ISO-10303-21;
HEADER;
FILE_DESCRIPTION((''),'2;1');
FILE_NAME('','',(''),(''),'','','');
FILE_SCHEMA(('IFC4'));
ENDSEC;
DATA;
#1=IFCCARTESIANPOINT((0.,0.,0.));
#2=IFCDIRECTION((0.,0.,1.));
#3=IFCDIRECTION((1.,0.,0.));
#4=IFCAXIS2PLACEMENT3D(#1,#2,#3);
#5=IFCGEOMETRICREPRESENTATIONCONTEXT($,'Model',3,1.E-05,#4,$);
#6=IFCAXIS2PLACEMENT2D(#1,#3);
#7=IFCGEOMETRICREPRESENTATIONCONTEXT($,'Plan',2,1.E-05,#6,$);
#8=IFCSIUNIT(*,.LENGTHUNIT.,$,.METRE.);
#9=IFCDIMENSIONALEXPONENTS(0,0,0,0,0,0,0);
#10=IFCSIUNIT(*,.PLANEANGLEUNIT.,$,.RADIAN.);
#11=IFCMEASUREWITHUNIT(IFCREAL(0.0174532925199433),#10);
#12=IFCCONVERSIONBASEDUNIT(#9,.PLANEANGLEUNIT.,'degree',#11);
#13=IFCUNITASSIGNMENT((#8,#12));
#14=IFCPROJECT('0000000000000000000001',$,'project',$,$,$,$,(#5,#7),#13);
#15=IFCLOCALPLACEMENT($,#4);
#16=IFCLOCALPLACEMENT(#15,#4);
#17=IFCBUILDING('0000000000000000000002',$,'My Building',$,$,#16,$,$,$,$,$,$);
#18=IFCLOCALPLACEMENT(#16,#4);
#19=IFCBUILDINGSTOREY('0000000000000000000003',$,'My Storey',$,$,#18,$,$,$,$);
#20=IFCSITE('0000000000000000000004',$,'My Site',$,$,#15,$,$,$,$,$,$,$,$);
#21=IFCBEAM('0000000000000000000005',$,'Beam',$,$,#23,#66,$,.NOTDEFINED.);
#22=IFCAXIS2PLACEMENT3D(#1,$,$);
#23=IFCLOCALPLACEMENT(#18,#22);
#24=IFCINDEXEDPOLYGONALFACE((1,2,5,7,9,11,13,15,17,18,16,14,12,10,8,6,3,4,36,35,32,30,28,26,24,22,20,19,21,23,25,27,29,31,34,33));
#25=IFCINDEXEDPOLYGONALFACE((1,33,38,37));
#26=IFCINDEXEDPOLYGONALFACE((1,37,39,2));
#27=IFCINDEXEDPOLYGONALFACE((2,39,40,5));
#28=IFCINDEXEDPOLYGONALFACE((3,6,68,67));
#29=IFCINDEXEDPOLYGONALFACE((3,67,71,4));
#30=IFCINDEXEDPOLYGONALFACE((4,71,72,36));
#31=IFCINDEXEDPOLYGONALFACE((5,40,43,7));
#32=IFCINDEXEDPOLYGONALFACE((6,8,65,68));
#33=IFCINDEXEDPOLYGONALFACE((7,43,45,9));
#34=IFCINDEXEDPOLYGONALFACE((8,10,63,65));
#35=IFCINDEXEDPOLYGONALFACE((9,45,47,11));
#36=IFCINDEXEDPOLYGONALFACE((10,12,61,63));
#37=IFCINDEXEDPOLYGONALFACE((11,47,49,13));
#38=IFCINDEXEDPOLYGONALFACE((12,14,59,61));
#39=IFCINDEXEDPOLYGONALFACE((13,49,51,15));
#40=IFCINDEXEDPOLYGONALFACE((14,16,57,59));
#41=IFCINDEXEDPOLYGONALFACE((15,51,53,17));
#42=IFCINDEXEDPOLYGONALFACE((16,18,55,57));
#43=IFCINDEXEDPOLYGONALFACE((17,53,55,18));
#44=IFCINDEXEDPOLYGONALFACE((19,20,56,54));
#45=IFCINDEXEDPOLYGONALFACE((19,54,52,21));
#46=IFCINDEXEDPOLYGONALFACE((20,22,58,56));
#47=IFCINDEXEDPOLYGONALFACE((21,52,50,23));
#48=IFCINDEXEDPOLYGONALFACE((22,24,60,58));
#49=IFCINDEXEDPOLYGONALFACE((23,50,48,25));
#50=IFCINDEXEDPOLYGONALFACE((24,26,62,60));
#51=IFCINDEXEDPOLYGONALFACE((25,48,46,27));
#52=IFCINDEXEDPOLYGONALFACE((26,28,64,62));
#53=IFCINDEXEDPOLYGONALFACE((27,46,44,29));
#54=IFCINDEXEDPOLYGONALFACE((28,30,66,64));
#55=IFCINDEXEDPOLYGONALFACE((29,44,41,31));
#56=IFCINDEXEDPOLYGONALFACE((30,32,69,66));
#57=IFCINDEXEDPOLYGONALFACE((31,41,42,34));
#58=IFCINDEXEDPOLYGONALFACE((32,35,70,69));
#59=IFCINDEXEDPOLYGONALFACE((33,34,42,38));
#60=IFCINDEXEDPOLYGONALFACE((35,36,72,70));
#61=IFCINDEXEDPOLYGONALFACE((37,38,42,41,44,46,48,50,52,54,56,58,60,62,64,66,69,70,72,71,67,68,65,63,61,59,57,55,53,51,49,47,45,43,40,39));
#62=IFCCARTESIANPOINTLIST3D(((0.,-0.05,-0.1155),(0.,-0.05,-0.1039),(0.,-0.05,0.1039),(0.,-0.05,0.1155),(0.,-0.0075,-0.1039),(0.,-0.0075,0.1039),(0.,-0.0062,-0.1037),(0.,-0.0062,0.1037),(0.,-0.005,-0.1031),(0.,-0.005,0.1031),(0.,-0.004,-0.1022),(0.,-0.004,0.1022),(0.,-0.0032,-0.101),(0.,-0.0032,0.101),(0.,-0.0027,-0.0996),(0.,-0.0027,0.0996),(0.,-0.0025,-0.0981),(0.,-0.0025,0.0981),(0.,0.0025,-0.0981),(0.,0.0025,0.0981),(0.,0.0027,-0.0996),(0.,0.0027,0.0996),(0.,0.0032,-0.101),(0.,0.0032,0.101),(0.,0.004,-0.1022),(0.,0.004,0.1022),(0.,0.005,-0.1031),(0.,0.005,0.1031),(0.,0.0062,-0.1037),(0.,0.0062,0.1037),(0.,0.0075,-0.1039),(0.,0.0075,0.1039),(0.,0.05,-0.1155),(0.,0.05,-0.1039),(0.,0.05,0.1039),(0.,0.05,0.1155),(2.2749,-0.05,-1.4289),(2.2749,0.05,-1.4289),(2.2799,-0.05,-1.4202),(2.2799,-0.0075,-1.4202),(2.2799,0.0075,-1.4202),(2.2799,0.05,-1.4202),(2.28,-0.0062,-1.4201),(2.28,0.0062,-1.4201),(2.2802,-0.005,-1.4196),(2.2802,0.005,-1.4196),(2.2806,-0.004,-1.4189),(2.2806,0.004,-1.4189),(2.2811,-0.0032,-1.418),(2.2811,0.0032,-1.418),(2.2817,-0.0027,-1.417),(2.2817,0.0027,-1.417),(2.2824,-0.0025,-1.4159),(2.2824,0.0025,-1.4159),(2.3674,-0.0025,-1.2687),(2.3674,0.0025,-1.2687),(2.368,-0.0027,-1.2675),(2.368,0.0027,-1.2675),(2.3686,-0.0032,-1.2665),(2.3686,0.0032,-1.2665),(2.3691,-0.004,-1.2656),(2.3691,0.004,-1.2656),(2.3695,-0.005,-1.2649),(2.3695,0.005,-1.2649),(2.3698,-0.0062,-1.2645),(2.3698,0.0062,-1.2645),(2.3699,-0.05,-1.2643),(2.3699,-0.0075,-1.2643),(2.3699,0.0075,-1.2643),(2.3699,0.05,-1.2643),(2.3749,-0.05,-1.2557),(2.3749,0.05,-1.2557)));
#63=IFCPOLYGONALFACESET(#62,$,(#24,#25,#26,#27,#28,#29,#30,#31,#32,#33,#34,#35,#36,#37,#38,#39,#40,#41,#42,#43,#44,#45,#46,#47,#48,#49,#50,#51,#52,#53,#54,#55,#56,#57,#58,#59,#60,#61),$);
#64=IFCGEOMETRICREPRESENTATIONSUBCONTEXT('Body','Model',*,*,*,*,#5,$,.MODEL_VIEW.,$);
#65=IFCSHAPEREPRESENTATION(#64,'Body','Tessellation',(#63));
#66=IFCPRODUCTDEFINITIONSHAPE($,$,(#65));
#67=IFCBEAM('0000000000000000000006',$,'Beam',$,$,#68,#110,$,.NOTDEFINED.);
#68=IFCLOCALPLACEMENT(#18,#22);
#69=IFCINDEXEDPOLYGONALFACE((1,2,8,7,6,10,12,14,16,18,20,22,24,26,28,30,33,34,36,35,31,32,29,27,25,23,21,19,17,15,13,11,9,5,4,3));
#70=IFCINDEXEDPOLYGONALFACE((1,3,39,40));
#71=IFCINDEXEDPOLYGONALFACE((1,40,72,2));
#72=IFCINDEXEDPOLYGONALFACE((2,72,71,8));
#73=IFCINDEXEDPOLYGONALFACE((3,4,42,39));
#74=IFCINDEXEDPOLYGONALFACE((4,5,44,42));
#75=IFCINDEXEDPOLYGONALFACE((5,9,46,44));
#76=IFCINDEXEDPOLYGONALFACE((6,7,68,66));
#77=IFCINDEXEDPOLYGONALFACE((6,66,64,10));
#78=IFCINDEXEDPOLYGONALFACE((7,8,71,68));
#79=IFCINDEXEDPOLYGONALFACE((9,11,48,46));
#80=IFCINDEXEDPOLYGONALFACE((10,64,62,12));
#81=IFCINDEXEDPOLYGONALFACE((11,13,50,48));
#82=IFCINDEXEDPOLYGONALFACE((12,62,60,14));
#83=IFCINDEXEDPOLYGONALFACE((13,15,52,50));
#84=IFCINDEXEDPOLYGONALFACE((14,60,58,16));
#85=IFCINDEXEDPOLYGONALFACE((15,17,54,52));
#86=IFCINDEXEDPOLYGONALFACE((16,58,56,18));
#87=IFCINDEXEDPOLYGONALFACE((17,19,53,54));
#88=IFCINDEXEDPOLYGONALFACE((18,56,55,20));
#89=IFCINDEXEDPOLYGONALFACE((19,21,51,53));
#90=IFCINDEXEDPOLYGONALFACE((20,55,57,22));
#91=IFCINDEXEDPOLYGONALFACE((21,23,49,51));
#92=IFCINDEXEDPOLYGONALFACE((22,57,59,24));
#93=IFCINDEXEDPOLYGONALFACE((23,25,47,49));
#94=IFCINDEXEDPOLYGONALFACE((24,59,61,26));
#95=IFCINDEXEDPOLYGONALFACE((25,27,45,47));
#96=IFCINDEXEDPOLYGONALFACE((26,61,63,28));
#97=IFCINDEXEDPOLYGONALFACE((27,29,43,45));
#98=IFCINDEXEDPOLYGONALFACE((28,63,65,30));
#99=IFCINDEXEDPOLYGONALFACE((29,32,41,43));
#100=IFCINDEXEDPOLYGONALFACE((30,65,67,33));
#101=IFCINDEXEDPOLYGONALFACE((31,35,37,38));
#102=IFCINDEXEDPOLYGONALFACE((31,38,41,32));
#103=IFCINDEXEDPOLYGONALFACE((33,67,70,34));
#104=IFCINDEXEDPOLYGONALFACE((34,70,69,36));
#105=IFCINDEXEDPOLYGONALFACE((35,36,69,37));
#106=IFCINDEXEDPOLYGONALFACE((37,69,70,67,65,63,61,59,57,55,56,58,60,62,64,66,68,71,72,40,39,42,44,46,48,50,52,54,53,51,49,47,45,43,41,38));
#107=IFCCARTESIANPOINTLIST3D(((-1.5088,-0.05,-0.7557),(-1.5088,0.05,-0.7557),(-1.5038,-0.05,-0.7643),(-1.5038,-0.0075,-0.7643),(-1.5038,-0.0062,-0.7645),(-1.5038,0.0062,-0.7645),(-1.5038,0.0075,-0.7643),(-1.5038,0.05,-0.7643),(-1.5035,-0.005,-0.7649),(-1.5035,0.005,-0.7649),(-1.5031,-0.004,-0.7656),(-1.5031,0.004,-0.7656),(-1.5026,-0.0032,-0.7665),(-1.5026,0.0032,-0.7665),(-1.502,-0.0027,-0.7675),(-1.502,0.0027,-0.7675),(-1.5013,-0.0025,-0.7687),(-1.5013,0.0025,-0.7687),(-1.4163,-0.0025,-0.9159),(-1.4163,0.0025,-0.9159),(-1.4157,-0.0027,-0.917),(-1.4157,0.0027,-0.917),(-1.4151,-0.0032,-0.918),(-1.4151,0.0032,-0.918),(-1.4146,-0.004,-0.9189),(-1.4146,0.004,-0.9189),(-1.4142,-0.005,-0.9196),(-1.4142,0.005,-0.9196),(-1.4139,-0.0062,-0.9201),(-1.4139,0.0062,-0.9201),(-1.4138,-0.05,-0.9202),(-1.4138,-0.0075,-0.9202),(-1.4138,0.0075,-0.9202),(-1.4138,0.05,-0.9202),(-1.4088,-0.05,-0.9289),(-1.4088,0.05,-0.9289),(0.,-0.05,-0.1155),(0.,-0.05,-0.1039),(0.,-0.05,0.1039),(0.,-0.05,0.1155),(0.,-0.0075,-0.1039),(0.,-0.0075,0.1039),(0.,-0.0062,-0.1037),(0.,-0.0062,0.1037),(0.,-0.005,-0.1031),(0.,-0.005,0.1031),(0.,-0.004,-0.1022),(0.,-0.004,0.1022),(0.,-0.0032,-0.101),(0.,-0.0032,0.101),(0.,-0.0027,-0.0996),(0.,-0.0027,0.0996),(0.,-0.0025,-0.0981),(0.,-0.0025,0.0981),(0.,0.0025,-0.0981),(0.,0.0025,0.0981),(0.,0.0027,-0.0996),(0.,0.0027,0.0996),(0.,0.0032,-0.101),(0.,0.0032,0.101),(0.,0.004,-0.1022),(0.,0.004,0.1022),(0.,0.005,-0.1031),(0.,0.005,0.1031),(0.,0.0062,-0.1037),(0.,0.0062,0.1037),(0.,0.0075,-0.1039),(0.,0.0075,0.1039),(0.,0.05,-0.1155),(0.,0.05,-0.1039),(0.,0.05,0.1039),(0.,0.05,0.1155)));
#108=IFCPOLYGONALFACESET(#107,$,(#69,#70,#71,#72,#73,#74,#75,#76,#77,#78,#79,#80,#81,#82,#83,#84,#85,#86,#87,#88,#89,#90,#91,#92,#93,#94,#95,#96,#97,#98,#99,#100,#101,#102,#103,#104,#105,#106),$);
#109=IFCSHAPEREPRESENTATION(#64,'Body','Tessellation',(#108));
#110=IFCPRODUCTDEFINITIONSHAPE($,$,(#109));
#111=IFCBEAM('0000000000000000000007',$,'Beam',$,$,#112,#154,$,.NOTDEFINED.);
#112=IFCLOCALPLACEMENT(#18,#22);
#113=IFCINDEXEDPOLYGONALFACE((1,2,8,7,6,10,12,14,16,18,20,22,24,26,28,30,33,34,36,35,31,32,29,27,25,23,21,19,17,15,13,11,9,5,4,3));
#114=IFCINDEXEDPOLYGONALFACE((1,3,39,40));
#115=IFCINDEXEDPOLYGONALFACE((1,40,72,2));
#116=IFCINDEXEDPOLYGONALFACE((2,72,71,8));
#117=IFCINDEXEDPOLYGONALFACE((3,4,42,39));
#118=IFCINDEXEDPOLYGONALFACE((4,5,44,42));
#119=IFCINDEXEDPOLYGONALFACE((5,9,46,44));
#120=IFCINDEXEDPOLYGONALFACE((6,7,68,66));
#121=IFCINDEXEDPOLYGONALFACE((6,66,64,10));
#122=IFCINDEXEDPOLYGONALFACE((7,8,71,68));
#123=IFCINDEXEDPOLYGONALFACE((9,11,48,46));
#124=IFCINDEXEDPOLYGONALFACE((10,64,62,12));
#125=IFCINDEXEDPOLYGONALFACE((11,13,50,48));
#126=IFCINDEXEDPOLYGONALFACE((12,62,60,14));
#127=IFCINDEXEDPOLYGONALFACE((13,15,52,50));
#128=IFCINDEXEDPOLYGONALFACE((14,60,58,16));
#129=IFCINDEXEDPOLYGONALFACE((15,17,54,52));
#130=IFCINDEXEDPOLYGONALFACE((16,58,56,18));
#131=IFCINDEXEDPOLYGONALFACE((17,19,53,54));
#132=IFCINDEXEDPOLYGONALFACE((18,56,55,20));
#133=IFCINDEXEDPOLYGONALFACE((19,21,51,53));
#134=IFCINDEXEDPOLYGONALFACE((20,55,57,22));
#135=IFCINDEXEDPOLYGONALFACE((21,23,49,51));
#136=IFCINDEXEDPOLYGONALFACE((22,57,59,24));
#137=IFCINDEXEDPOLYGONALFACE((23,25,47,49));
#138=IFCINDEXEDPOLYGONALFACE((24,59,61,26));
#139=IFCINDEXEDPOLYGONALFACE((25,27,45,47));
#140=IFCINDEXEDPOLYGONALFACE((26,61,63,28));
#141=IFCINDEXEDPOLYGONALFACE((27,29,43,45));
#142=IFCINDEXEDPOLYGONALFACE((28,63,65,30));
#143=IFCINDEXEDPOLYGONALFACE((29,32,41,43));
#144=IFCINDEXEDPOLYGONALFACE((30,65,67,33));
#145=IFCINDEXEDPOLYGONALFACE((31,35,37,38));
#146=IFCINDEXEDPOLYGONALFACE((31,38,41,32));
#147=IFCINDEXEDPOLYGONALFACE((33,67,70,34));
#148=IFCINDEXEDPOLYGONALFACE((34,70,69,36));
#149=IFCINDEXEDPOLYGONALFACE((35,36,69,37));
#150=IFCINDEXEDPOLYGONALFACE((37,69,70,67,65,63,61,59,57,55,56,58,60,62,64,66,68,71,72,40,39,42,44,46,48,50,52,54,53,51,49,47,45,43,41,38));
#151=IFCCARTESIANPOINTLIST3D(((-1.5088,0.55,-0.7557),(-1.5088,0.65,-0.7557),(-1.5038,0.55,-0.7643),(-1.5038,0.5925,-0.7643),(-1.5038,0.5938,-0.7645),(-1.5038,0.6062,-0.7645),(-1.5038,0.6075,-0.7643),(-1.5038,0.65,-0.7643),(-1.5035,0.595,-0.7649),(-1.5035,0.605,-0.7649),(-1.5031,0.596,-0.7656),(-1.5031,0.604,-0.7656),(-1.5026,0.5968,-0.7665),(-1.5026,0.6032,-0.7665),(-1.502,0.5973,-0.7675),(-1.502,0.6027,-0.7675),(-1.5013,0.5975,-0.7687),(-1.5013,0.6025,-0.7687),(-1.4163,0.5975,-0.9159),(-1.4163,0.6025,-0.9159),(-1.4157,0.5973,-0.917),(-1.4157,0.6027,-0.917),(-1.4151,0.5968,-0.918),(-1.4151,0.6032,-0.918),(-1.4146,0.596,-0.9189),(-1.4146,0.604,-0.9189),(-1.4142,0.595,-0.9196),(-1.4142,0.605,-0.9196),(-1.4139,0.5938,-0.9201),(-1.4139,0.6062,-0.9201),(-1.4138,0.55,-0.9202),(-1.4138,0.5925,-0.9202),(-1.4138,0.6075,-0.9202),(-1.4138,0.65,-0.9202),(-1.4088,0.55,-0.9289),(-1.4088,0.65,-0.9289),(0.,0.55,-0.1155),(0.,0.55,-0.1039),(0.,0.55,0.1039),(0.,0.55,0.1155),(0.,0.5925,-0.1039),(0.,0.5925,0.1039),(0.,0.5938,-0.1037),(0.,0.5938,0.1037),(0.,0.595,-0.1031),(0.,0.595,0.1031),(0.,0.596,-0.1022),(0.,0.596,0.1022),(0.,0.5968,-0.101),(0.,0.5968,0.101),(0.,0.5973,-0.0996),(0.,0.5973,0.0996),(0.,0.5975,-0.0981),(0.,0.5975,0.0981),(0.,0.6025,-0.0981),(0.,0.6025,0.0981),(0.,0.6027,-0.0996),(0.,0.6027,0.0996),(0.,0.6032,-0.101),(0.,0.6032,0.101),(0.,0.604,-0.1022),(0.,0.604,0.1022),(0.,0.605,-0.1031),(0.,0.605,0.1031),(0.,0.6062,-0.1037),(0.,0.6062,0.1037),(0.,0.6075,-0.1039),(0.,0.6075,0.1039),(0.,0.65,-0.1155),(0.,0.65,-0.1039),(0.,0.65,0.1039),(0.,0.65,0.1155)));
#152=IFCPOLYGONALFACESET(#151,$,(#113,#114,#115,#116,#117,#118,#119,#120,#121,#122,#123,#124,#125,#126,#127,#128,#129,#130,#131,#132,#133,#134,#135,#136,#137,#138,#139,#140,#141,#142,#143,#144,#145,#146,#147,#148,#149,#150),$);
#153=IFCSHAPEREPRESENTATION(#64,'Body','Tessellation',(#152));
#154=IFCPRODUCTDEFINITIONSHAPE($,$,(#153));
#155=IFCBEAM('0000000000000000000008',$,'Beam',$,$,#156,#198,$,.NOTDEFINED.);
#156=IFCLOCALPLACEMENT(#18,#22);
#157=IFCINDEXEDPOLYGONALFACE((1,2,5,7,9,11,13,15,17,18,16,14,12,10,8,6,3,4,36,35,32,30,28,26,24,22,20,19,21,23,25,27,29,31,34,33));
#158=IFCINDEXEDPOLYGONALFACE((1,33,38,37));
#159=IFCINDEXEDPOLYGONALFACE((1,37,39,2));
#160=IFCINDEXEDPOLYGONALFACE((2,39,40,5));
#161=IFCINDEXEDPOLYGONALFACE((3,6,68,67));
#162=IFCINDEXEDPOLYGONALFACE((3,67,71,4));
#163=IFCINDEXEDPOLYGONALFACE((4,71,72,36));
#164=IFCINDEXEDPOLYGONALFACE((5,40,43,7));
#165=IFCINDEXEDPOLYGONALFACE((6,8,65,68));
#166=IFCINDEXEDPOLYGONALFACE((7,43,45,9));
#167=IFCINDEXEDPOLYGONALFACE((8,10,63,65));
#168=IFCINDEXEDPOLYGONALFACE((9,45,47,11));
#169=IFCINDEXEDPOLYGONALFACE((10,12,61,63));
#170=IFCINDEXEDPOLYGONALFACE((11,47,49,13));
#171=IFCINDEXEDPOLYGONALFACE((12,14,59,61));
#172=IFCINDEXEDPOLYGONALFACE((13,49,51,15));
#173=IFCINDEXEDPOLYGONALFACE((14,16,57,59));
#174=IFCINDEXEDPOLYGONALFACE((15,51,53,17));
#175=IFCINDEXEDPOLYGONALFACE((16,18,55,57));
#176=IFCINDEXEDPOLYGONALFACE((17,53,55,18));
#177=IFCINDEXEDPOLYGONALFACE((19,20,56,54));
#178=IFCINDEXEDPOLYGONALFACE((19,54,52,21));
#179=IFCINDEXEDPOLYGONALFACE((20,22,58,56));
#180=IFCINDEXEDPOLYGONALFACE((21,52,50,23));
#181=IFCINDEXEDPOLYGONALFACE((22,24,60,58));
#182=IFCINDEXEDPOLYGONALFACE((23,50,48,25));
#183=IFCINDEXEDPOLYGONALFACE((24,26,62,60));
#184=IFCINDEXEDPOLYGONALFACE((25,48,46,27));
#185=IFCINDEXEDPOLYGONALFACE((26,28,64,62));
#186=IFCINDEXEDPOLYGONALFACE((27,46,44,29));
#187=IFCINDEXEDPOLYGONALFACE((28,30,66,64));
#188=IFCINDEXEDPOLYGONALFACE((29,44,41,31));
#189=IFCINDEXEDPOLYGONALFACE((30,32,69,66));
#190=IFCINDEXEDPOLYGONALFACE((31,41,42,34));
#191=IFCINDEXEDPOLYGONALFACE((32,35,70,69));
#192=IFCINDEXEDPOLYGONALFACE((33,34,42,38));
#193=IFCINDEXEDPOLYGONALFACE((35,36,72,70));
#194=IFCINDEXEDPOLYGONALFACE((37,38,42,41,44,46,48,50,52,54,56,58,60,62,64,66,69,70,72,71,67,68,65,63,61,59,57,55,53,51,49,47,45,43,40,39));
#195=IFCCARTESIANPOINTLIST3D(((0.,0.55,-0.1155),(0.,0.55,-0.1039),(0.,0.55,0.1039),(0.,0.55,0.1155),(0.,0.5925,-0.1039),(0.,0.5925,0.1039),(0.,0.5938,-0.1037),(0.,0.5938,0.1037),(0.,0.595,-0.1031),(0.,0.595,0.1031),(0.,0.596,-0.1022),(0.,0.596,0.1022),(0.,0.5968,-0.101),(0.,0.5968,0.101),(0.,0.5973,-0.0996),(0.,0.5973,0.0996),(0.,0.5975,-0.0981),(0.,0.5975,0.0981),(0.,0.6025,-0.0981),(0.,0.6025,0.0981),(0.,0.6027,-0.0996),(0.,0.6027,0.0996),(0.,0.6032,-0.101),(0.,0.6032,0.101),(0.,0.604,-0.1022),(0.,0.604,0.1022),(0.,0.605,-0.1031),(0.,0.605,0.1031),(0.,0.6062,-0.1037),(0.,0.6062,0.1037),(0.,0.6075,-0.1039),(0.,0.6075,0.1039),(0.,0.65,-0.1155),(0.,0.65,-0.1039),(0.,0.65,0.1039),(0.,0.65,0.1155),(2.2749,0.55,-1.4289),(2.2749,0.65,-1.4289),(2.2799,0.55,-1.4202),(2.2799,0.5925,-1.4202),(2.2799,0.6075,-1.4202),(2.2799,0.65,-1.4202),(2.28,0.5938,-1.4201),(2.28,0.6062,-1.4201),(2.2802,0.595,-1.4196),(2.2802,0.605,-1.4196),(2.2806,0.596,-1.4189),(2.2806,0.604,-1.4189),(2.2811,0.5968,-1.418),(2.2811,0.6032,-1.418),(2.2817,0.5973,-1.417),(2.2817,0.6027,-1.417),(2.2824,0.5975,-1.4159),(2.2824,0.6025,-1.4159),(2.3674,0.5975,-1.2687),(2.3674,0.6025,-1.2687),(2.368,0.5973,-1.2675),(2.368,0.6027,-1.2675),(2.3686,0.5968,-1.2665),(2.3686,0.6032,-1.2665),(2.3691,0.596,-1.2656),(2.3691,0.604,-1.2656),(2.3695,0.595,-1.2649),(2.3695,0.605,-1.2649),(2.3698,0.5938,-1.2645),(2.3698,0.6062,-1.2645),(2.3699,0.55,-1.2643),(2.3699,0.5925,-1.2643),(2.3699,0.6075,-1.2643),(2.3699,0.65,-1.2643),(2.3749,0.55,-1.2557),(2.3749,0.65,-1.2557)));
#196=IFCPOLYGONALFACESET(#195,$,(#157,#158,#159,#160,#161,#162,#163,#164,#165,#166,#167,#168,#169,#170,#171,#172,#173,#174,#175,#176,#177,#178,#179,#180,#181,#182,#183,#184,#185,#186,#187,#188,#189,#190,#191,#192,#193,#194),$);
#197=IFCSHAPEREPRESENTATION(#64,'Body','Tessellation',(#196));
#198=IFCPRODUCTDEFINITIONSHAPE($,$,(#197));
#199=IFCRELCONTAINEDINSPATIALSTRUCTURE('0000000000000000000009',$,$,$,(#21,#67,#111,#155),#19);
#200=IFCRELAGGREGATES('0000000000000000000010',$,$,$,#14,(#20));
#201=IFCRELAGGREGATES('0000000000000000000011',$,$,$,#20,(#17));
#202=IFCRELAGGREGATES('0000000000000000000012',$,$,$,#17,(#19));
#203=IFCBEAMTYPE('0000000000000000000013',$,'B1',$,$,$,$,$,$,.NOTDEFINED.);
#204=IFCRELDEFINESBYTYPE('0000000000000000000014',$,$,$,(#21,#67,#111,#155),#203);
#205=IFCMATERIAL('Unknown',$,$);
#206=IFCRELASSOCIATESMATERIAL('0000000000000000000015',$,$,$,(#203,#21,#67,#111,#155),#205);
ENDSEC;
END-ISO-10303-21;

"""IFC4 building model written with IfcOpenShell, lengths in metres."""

from ifc_helpers import new_model, entity, si_unit, converted_unit, frame, frame_2d, origin_with_axes, place, context, subcontext, project, spatial, i_section, extrude, clip, halfspace, material, material_profile, profile_set, profile_usage, type_object, element, save


model = new_model("IFC4")

# Units and contexts
model_context = context("Model", 3, precision=1e-05, world=origin_with_axes())
plan_context = context("Plan", 2, precision=1e-05, world=frame_2d((0.0, 0.0, 0.0), x_axis=(1.0, 0.0, 0.0)))
body_context = subcontext(model_context, "Body", "Model", "MODEL_VIEW")
ifc_project = project(units=[si_unit("LENGTHUNIT", "METRE"), converted_unit("PLANEANGLEUNIT", "degree", entity("IfcReal", 0.0174532925199433), si_unit("PLANEANGLEUNIT", "RADIAN"), dimensions=[0, 0, 0, 0, 0, 0, 0])], contexts=[model_context, plan_context])

# Site, building, storey
site_placement = place(None, origin_with_axes())
site = spatial("IfcSite", under=ifc_project, at=site_placement, Name="My Site")
building_placement = place(site_placement, origin_with_axes())
building = spatial("IfcBuilding", under=site, at=building_placement, Name="My Building")
storey_placement = place(building_placement, origin_with_axes())
storey = spatial("IfcBuildingStorey", under=building, at=storey_placement, Name="My Storey")

# Beams
ifc_material = material(Name="Unknown")
ifc_material_profile = material_profile(ifc_material, i_section(OverallWidth=0.1, OverallDepth=0.2, WebThickness=0.005, FlangeThickness=0.01, FilletRadius=0.005))
ifc_profile_set = profile_set([ifc_material_profile])
ifc_profile_usage_1 = profile_usage(ifc_profile_set, cardinal=5)
beam_type = type_object("IfcBeamType", Name="B1", PredefinedType="NOTDEFINED", material=ifc_profile_set)
beam_1_placement = place(storey_placement, frame((-0.2732, 0.0, 0.1577), z_axis=(0.866025, 0.0, -0.5), x_axis=(0.0, 1.0, 0.0)))
element("IfcBeam", 1, at=beam_1_placement, inside=storey, type_object=beam_type, material=ifc_profile_usage_1, Name="Beam", PredefinedType="NOTDEFINED", context=body_context, shape_type="Clipping", body=[
    clip(extrude(i_section(OverallWidth=0.1, OverallDepth=0.2, WebThickness=0.005, FlangeThickness=0.01, FilletRadius=0.005), origin_with_axes(), (0.0, 0.0, 1.0), 3.0), halfspace(frame((0.0, 0.1, 0.2577), z_axis=(0.0, -0.5, -0.866025), x_axis=(0.0, -0.866025, 0.5)), False)),
])
ifc_profile_usage_2 = profile_usage(ifc_profile_set, cardinal=5)
beam_2_placement = place(storey_placement, frame((0.2732, 0.0, 0.1577), z_axis=(-0.866025, 0.0, -0.5), x_axis=(0.0, -1.0, 0.0)))
element("IfcBeam", 2, at=beam_2_placement, inside=storey, type_object=beam_type, material=ifc_profile_usage_2, Name="Beam", PredefinedType="NOTDEFINED", context=body_context, shape_type="Clipping", body=[
    clip(extrude(i_section(OverallWidth=0.1, OverallDepth=0.2, WebThickness=0.005, FlangeThickness=0.01, FilletRadius=0.005), origin_with_axes(), (0.0, 0.0, 1.0), 2.0), halfspace(frame((0.0, 0.1, 0.2577), z_axis=(0.0, -0.5, -0.866025), x_axis=(0.0, -0.866025, 0.5)), False)),
])
ifc_profile_usage_3 = profile_usage(ifc_profile_set, cardinal=5)
beam_3_placement = place(storey_placement, frame((0.2732, 0.6, 0.1577), z_axis=(-0.866025, 0.0, -0.5), x_axis=(0.0, -1.0, 0.0)))
element("IfcBeam", 3, at=beam_3_placement, inside=storey, type_object=beam_type, material=ifc_profile_usage_3, Name="Beam", PredefinedType="NOTDEFINED", context=body_context, shape_type="Clipping", body=[
    clip(extrude(i_section(OverallWidth=0.1, OverallDepth=0.2, WebThickness=0.005, FlangeThickness=0.01, FilletRadius=0.005), origin_with_axes(), (0.0, 0.0, 1.0), 2.0), halfspace(frame((0.6, 0.1, 0.2577), z_axis=(0.0, -0.5, -0.866025), x_axis=(0.0, -0.866025, 0.5)), False)),
])
ifc_profile_usage_4 = profile_usage(ifc_profile_set, cardinal=5)
beam_4_placement = place(storey_placement, frame((-0.2732, 0.6, 0.1577), z_axis=(0.866025, 0.0, -0.5), x_axis=(0.0, 1.0, 0.0)))
element("IfcBeam", 4, at=beam_4_placement, inside=storey, type_object=beam_type, material=ifc_profile_usage_4, Name="Beam", PredefinedType="NOTDEFINED", context=body_context, shape_type="Clipping", body=[
    clip(extrude(i_section(OverallWidth=0.1, OverallDepth=0.2, WebThickness=0.005, FlangeThickness=0.01, FilletRadius=0.005), origin_with_axes(), (0.0, 0.0, 1.0), 3.0), halfspace(frame((-0.6, 0.1, 0.2577), z_axis=(0.0, -0.5, -0.866025), x_axis=(0.0, -0.866025, 0.5)), False)),
])

save(model, "model.ifc")
